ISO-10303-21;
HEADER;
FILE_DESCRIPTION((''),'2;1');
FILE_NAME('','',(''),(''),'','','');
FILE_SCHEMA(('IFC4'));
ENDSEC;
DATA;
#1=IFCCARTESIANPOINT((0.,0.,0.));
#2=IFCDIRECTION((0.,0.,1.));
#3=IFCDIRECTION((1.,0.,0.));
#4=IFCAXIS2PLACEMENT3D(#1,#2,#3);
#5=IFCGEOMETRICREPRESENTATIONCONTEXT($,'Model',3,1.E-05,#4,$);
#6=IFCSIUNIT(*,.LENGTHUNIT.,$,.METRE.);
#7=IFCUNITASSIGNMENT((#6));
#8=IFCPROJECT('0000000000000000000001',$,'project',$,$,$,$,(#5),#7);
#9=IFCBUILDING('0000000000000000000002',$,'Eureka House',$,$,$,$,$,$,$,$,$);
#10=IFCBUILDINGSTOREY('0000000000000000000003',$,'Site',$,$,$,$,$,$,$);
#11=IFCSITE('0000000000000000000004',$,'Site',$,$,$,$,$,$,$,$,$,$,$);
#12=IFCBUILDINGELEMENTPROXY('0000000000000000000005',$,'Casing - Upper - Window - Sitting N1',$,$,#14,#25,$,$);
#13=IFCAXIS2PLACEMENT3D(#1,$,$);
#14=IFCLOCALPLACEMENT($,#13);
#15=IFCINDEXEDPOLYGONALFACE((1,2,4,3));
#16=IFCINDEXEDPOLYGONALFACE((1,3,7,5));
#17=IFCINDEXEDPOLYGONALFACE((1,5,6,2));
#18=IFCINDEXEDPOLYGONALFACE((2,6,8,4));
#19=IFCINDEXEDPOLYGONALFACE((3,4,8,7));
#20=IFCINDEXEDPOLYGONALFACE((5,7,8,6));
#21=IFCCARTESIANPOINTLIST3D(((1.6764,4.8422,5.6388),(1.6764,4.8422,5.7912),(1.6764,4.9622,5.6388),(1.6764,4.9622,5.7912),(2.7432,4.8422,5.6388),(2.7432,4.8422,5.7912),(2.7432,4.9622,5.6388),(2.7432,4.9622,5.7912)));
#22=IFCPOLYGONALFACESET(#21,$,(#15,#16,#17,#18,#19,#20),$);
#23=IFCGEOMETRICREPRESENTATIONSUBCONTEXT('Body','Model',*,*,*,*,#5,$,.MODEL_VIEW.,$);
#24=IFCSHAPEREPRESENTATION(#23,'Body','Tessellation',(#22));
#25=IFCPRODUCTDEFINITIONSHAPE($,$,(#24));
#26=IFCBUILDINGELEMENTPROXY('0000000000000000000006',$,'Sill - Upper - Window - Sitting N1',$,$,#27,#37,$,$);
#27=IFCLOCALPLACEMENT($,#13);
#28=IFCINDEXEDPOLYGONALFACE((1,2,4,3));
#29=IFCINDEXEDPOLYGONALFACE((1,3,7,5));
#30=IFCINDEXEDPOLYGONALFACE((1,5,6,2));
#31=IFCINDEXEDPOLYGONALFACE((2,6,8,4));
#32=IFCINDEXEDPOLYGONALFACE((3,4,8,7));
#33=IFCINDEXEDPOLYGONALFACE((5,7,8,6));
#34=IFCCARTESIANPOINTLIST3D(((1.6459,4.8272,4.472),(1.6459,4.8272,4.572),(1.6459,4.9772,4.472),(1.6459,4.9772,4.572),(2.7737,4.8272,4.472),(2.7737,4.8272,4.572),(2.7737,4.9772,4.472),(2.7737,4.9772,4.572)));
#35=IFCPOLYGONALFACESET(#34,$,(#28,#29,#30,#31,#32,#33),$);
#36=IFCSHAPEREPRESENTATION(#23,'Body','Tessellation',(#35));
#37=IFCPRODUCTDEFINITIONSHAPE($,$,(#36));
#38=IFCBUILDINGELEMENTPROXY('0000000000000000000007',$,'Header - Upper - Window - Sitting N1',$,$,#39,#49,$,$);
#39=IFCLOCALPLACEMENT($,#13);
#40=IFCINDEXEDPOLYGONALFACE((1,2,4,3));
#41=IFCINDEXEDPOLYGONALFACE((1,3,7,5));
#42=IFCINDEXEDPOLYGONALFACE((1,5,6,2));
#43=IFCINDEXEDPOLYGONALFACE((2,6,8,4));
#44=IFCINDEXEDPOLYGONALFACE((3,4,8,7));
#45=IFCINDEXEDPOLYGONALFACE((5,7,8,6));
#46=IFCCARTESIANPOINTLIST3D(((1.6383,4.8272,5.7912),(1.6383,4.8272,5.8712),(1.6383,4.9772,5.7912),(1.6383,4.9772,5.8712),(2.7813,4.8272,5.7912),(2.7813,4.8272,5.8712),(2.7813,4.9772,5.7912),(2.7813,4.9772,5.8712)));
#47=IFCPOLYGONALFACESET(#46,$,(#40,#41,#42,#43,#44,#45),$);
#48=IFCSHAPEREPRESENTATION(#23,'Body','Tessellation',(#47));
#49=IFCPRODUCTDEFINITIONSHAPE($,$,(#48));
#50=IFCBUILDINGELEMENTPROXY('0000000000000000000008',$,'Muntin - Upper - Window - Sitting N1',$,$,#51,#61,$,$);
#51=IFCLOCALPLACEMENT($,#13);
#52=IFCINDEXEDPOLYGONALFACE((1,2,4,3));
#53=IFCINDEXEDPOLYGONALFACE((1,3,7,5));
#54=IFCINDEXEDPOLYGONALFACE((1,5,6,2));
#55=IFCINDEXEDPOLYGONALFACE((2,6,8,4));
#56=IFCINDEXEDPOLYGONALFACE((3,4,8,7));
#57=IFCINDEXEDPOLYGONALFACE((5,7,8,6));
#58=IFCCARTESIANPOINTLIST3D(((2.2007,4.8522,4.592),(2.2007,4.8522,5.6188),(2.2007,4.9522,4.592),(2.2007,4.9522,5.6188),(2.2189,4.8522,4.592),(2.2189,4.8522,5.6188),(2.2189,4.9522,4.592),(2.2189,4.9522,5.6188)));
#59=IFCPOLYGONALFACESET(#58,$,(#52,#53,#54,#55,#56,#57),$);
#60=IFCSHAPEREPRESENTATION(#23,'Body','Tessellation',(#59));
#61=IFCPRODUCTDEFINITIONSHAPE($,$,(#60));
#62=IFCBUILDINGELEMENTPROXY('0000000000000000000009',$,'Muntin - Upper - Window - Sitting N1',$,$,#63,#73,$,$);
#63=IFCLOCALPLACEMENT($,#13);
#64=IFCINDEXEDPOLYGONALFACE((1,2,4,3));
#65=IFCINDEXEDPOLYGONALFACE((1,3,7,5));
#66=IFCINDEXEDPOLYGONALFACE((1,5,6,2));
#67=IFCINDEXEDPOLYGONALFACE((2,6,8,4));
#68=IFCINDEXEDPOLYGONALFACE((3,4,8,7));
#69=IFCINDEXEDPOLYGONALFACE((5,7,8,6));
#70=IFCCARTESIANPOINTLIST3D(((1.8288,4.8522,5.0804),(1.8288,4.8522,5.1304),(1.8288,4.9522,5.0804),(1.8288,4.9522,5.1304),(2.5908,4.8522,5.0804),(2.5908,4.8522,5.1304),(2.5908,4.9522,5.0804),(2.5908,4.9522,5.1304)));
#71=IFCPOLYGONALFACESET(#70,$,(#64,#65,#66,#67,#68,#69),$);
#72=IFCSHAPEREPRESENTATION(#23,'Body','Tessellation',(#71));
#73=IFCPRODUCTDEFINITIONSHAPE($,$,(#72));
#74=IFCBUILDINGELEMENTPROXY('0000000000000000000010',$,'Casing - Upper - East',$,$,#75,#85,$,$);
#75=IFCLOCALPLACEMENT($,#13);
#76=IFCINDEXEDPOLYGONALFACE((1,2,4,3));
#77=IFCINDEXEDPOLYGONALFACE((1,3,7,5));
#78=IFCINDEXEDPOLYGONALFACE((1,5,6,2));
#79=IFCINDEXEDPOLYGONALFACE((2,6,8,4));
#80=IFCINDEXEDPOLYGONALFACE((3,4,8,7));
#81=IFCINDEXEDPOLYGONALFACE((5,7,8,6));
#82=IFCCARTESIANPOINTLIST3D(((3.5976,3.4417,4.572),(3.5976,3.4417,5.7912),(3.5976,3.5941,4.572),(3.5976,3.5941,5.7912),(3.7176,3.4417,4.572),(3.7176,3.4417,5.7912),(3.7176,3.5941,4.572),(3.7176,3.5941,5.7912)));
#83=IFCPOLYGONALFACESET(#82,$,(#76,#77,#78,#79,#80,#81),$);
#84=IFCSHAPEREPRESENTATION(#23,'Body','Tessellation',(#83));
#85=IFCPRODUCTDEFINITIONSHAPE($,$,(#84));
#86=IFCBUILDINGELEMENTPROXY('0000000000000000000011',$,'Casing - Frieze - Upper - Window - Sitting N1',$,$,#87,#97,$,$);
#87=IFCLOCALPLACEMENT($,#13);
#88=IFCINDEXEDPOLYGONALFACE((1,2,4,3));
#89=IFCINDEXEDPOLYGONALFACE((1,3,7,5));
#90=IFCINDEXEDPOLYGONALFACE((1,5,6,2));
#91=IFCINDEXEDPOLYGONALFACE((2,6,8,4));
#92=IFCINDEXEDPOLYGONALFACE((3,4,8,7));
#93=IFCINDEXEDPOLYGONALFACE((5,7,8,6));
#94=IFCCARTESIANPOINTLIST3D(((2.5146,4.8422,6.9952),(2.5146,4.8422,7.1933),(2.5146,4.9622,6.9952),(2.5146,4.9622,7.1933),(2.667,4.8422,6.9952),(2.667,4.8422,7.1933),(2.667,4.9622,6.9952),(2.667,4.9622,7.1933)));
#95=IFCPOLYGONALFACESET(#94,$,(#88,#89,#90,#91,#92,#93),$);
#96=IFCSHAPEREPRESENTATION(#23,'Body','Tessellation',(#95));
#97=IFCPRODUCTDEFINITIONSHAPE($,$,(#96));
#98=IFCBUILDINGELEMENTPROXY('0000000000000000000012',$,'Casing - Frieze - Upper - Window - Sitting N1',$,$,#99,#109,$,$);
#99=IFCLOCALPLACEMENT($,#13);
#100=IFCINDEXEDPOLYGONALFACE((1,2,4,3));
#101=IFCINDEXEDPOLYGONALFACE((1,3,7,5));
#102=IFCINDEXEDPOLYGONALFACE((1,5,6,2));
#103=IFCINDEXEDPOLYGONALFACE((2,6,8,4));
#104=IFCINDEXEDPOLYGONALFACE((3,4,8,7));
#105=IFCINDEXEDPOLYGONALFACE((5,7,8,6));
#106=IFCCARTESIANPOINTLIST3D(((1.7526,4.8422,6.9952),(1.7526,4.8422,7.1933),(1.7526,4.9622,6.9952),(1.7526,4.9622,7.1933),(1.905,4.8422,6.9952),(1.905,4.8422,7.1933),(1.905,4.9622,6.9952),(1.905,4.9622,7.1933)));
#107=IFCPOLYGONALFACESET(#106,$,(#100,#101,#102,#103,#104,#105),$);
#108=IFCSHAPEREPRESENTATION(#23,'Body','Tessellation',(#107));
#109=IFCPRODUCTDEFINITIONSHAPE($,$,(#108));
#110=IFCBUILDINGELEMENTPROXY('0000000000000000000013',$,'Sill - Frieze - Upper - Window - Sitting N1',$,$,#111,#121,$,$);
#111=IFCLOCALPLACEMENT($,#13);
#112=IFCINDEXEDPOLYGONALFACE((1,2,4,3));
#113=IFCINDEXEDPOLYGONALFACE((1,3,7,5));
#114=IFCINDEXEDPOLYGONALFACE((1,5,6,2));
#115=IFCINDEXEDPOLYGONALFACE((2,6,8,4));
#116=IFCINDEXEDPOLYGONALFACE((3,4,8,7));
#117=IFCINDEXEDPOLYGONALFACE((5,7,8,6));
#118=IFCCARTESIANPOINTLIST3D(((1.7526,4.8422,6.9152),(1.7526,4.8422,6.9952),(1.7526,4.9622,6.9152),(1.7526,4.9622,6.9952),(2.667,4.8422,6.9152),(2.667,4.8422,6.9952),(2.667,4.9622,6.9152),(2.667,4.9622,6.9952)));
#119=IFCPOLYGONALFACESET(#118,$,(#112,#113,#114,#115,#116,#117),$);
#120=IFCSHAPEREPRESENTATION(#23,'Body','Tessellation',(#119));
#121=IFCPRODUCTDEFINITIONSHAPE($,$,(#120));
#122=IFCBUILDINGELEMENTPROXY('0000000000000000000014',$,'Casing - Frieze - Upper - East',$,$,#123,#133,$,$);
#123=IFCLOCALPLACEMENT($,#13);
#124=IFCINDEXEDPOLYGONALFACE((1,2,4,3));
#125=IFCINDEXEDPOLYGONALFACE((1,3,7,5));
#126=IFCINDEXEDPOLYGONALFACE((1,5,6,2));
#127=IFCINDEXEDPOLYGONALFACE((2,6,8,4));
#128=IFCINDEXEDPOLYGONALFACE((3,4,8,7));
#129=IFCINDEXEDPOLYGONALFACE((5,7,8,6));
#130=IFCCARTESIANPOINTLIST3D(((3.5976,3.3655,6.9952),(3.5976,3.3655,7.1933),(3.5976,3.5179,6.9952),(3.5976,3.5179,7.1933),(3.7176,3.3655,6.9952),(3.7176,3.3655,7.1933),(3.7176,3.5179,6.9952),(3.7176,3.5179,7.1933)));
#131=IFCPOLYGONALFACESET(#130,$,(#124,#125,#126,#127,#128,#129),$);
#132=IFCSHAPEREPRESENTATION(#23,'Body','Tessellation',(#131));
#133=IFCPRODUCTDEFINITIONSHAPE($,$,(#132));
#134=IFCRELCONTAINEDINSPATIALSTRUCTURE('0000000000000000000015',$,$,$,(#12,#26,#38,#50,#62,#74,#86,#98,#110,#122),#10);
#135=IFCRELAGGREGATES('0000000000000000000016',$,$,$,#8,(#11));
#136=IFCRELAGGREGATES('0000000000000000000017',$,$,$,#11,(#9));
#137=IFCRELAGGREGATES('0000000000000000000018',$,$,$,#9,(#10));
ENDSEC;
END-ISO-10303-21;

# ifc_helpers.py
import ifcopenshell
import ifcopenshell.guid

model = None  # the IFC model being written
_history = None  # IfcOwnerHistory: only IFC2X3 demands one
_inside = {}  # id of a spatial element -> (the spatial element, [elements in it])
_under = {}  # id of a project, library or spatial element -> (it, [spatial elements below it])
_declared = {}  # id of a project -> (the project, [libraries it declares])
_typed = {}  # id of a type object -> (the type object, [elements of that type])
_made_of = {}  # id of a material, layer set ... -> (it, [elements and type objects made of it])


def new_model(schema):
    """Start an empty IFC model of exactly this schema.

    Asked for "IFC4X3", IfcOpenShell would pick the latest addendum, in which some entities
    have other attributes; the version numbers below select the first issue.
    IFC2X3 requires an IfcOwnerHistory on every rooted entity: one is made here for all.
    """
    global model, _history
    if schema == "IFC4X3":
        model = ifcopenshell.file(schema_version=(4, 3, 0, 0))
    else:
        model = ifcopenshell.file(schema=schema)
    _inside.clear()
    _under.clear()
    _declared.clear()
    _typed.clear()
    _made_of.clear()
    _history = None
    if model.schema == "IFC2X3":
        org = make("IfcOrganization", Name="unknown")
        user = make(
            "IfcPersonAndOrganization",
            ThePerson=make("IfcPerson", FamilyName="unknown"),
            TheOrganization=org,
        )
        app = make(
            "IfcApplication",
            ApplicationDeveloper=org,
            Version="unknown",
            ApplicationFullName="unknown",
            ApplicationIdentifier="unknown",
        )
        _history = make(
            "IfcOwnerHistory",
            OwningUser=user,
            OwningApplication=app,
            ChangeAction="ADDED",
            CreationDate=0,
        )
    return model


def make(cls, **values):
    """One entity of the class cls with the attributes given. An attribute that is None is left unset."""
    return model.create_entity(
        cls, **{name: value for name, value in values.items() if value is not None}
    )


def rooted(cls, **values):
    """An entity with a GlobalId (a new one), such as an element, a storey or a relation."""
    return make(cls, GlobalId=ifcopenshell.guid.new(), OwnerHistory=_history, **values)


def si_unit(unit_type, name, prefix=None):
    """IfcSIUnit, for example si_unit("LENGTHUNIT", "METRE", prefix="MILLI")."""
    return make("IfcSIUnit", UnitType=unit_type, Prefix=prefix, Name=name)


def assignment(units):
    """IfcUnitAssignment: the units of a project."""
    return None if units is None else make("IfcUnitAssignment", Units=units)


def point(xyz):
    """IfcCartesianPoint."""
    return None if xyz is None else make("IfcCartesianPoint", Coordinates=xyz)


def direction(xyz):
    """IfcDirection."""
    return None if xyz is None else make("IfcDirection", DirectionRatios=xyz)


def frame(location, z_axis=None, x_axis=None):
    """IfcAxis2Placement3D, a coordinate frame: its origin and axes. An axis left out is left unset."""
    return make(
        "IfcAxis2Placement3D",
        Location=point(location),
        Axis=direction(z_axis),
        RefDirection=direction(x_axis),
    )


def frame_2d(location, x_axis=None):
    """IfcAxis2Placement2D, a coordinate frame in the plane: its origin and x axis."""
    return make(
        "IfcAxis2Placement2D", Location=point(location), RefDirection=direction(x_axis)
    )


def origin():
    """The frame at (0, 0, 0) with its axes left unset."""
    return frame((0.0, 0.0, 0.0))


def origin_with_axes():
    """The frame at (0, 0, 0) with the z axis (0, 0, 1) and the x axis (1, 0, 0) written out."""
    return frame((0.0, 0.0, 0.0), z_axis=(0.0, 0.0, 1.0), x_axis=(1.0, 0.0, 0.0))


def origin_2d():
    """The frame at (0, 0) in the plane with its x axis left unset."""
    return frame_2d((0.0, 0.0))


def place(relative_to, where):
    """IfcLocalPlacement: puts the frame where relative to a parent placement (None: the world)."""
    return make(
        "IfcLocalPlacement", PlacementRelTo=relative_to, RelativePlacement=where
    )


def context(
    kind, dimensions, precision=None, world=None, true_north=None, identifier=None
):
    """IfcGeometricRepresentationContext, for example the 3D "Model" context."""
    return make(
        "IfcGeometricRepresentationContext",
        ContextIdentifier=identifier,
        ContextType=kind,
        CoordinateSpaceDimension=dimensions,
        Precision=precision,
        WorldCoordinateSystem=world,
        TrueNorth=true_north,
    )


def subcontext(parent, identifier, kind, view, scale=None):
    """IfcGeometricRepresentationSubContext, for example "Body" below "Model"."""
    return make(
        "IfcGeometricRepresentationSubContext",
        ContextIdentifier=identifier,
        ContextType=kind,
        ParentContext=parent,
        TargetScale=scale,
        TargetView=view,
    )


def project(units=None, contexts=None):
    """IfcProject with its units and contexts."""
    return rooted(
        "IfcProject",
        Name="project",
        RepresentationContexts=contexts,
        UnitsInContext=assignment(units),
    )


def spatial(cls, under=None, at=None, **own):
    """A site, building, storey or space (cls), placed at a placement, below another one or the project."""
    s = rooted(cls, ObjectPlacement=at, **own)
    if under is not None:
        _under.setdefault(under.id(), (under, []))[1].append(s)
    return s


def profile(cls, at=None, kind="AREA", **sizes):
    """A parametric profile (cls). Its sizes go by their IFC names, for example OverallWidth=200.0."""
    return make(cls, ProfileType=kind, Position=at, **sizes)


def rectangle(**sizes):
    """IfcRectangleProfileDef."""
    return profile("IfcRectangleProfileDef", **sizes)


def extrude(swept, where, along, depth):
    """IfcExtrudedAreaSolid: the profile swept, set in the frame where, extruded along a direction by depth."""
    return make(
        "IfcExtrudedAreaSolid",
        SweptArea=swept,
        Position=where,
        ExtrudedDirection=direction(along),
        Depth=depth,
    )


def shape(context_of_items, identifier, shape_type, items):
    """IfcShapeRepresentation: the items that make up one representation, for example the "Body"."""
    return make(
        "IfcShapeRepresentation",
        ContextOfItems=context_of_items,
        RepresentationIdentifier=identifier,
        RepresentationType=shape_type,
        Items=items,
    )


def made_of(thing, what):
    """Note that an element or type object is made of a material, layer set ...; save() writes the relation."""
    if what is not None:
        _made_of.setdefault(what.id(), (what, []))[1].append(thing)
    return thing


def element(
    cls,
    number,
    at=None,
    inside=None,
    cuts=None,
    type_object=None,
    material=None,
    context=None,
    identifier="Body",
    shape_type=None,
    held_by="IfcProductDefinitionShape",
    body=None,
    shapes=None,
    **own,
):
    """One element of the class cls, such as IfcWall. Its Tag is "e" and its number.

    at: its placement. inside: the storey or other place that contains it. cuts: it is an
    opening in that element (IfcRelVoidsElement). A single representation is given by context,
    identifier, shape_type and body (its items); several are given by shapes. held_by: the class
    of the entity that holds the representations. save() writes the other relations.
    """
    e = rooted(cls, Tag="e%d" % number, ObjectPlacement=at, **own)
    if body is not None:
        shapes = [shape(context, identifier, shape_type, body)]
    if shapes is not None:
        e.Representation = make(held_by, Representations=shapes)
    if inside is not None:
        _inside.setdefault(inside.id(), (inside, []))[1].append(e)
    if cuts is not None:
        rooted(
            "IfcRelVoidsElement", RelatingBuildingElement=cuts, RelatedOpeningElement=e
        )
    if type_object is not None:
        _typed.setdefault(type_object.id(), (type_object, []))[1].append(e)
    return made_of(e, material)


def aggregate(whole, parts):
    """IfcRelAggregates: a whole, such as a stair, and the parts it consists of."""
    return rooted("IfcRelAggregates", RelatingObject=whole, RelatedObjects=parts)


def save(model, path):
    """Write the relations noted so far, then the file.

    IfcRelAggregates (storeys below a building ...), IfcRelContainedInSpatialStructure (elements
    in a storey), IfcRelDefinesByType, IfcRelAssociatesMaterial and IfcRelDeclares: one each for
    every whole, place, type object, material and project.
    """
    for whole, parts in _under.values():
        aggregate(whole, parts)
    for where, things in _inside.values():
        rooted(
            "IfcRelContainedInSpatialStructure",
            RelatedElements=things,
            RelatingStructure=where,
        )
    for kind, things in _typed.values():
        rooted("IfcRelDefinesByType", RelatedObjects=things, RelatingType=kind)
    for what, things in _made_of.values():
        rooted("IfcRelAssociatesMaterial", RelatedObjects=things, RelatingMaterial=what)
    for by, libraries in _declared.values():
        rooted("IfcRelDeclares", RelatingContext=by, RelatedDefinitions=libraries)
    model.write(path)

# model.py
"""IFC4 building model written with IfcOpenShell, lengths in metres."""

from ifc_helpers import new_model, si_unit, frame, origin, origin_with_axes, origin_2d, place, context, subcontext, project, spatial, rectangle, extrude, element, save


model = new_model("IFC4")

# Units and contexts
model_context = context("Model", 3, precision=1e-05, world=origin_with_axes())
body_context = subcontext(model_context, "Body", "Model", "MODEL_VIEW")
ifc_project = project(units=[si_unit("LENGTHUNIT", "METRE")], contexts=[model_context])

# Site, building, storey
site = spatial("IfcSite", under=ifc_project, Name="Site")
building = spatial("IfcBuilding", under=site, Name="Eureka House")
storey = spatial("IfcBuildingStorey", under=building, Name="Site")

# Building element proxies
proxy_1_placement = place(None, frame((2.2098, 4.9022, 5.6388), z_axis=(0.0, 0.0, 1.0), x_axis=(1.0, 0.0, 0.0)))
element("IfcBuildingElementProxy", 1, at=proxy_1_placement, inside=storey, Name="Casing - Upper - Window - Sitting N1", context=body_context, shape_type="SweptSolid", body=[
    extrude(rectangle(XDim=1.0668, YDim=0.12, at=origin_2d()), origin(), (0.0, 0.0, 1.0), 0.1524),
])
proxy_2_placement = place(None, frame((2.2098, 4.9022, 4.472), z_axis=(0.0, 0.0, 1.0), x_axis=(1.0, 0.0, 0.0)))
element("IfcBuildingElementProxy", 2, at=proxy_2_placement, inside=storey, Name="Sill - Upper - Window - Sitting N1", context=body_context, shape_type="SweptSolid", body=[
    extrude(rectangle(XDim=1.1278, YDim=0.15, at=origin_2d()), origin(), (0.0, 0.0, 1.0), 0.1),
])
proxy_3_placement = place(None, frame((2.2098, 4.9022, 5.7912), z_axis=(0.0, 0.0, 1.0), x_axis=(1.0, 0.0, 0.0)))
element("IfcBuildingElementProxy", 3, at=proxy_3_placement, inside=storey, Name="Header - Upper - Window - Sitting N1", context=body_context, shape_type="SweptSolid", body=[
    extrude(rectangle(XDim=1.143, YDim=0.15, at=origin_2d()), origin(), (0.0, 0.0, 1.0), 0.08),
])
proxy_4_placement = place(None, frame((2.2098, 4.9022, 4.592), z_axis=(0.0, 0.0, 1.0), x_axis=(1.0, 0.0, 0.0)))
element("IfcBuildingElementProxy", 4, at=proxy_4_placement, inside=storey, Name="Muntin - Upper - Window - Sitting N1", context=body_context, shape_type="SweptSolid", body=[
    extrude(rectangle(XDim=0.0183, YDim=0.1, at=origin_2d()), origin(), (0.0, 0.0, 1.0), 1.0268),
])
proxy_5_placement = place(None, frame((2.2098, 4.9022, 5.0804), z_axis=(0.0, 0.0, 1.0), x_axis=(1.0, 0.0, 0.0)))
element("IfcBuildingElementProxy", 5, at=proxy_5_placement, inside=storey, Name="Muntin - Upper - Window - Sitting N1", context=body_context, shape_type="SweptSolid", body=[
    extrude(rectangle(XDim=0.762, YDim=0.1, at=origin_2d()), origin(), (0.0, 0.0, 1.0), 0.05),
])
proxy_6_placement = place(None, frame((3.6576, 3.5179, 4.572), z_axis=(0.0, 0.0, 1.0), x_axis=(1.0, 0.0, 0.0)))
element("IfcBuildingElementProxy", 6, at=proxy_6_placement, inside=storey, Name="Casing - Upper - East", context=body_context, shape_type="SweptSolid", body=[
    extrude(rectangle(XDim=0.12, YDim=0.1524, at=origin_2d()), origin(), (0.0, 0.0, 1.0), 1.2192),
])
for number, where, z_axis, x_axis, name in (
    (7, (2.5908, 4.9022, 6.9952), (0.0, 0.0, 1.0), (1.0, 0.0, 0.0), "Casing - Frieze - Upper - Window - Sitting N1"),
    (8, (1.8288, 4.9022, 6.9952), (0.0, 0.0, 1.0), (1.0, 0.0, 0.0), "Casing - Frieze - Upper - Window - Sitting N1"),
):
    element("IfcBuildingElementProxy", number, at=place(None, frame(where, z_axis=z_axis, x_axis=x_axis)), inside=storey, Name=name, context=body_context, shape_type="SweptSolid", body=[
        extrude(rectangle(XDim=0.1524, YDim=0.12, at=origin_2d()), origin(), (0.0, 0.0, 1.0), 0.1981),
    ])
proxy_7_placement = place(None, frame((2.2098, 4.9022, 6.9152), z_axis=(0.0, 0.0, 1.0), x_axis=(1.0, 0.0, 0.0)))
element("IfcBuildingElementProxy", 9, at=proxy_7_placement, inside=storey, Name="Sill - Frieze - Upper - Window - Sitting N1", context=body_context, shape_type="SweptSolid", body=[
    extrude(rectangle(XDim=0.9144, YDim=0.12, at=origin_2d()), origin(), (0.0, 0.0, 1.0), 0.08),
])
proxy_8_placement = place(None, frame((3.6576, 3.4417, 6.9952), z_axis=(0.0, 0.0, 1.0), x_axis=(1.0, 0.0, 0.0)))
element("IfcBuildingElementProxy", 10, at=proxy_8_placement, inside=storey, Name="Casing - Frieze - Upper - East", context=body_context, shape_type="SweptSolid", body=[
    extrude(rectangle(XDim=0.12, YDim=0.1524, at=origin_2d()), origin(), (0.0, 0.0, 1.0), 0.1981),
])

save(model, "model.ifc")
